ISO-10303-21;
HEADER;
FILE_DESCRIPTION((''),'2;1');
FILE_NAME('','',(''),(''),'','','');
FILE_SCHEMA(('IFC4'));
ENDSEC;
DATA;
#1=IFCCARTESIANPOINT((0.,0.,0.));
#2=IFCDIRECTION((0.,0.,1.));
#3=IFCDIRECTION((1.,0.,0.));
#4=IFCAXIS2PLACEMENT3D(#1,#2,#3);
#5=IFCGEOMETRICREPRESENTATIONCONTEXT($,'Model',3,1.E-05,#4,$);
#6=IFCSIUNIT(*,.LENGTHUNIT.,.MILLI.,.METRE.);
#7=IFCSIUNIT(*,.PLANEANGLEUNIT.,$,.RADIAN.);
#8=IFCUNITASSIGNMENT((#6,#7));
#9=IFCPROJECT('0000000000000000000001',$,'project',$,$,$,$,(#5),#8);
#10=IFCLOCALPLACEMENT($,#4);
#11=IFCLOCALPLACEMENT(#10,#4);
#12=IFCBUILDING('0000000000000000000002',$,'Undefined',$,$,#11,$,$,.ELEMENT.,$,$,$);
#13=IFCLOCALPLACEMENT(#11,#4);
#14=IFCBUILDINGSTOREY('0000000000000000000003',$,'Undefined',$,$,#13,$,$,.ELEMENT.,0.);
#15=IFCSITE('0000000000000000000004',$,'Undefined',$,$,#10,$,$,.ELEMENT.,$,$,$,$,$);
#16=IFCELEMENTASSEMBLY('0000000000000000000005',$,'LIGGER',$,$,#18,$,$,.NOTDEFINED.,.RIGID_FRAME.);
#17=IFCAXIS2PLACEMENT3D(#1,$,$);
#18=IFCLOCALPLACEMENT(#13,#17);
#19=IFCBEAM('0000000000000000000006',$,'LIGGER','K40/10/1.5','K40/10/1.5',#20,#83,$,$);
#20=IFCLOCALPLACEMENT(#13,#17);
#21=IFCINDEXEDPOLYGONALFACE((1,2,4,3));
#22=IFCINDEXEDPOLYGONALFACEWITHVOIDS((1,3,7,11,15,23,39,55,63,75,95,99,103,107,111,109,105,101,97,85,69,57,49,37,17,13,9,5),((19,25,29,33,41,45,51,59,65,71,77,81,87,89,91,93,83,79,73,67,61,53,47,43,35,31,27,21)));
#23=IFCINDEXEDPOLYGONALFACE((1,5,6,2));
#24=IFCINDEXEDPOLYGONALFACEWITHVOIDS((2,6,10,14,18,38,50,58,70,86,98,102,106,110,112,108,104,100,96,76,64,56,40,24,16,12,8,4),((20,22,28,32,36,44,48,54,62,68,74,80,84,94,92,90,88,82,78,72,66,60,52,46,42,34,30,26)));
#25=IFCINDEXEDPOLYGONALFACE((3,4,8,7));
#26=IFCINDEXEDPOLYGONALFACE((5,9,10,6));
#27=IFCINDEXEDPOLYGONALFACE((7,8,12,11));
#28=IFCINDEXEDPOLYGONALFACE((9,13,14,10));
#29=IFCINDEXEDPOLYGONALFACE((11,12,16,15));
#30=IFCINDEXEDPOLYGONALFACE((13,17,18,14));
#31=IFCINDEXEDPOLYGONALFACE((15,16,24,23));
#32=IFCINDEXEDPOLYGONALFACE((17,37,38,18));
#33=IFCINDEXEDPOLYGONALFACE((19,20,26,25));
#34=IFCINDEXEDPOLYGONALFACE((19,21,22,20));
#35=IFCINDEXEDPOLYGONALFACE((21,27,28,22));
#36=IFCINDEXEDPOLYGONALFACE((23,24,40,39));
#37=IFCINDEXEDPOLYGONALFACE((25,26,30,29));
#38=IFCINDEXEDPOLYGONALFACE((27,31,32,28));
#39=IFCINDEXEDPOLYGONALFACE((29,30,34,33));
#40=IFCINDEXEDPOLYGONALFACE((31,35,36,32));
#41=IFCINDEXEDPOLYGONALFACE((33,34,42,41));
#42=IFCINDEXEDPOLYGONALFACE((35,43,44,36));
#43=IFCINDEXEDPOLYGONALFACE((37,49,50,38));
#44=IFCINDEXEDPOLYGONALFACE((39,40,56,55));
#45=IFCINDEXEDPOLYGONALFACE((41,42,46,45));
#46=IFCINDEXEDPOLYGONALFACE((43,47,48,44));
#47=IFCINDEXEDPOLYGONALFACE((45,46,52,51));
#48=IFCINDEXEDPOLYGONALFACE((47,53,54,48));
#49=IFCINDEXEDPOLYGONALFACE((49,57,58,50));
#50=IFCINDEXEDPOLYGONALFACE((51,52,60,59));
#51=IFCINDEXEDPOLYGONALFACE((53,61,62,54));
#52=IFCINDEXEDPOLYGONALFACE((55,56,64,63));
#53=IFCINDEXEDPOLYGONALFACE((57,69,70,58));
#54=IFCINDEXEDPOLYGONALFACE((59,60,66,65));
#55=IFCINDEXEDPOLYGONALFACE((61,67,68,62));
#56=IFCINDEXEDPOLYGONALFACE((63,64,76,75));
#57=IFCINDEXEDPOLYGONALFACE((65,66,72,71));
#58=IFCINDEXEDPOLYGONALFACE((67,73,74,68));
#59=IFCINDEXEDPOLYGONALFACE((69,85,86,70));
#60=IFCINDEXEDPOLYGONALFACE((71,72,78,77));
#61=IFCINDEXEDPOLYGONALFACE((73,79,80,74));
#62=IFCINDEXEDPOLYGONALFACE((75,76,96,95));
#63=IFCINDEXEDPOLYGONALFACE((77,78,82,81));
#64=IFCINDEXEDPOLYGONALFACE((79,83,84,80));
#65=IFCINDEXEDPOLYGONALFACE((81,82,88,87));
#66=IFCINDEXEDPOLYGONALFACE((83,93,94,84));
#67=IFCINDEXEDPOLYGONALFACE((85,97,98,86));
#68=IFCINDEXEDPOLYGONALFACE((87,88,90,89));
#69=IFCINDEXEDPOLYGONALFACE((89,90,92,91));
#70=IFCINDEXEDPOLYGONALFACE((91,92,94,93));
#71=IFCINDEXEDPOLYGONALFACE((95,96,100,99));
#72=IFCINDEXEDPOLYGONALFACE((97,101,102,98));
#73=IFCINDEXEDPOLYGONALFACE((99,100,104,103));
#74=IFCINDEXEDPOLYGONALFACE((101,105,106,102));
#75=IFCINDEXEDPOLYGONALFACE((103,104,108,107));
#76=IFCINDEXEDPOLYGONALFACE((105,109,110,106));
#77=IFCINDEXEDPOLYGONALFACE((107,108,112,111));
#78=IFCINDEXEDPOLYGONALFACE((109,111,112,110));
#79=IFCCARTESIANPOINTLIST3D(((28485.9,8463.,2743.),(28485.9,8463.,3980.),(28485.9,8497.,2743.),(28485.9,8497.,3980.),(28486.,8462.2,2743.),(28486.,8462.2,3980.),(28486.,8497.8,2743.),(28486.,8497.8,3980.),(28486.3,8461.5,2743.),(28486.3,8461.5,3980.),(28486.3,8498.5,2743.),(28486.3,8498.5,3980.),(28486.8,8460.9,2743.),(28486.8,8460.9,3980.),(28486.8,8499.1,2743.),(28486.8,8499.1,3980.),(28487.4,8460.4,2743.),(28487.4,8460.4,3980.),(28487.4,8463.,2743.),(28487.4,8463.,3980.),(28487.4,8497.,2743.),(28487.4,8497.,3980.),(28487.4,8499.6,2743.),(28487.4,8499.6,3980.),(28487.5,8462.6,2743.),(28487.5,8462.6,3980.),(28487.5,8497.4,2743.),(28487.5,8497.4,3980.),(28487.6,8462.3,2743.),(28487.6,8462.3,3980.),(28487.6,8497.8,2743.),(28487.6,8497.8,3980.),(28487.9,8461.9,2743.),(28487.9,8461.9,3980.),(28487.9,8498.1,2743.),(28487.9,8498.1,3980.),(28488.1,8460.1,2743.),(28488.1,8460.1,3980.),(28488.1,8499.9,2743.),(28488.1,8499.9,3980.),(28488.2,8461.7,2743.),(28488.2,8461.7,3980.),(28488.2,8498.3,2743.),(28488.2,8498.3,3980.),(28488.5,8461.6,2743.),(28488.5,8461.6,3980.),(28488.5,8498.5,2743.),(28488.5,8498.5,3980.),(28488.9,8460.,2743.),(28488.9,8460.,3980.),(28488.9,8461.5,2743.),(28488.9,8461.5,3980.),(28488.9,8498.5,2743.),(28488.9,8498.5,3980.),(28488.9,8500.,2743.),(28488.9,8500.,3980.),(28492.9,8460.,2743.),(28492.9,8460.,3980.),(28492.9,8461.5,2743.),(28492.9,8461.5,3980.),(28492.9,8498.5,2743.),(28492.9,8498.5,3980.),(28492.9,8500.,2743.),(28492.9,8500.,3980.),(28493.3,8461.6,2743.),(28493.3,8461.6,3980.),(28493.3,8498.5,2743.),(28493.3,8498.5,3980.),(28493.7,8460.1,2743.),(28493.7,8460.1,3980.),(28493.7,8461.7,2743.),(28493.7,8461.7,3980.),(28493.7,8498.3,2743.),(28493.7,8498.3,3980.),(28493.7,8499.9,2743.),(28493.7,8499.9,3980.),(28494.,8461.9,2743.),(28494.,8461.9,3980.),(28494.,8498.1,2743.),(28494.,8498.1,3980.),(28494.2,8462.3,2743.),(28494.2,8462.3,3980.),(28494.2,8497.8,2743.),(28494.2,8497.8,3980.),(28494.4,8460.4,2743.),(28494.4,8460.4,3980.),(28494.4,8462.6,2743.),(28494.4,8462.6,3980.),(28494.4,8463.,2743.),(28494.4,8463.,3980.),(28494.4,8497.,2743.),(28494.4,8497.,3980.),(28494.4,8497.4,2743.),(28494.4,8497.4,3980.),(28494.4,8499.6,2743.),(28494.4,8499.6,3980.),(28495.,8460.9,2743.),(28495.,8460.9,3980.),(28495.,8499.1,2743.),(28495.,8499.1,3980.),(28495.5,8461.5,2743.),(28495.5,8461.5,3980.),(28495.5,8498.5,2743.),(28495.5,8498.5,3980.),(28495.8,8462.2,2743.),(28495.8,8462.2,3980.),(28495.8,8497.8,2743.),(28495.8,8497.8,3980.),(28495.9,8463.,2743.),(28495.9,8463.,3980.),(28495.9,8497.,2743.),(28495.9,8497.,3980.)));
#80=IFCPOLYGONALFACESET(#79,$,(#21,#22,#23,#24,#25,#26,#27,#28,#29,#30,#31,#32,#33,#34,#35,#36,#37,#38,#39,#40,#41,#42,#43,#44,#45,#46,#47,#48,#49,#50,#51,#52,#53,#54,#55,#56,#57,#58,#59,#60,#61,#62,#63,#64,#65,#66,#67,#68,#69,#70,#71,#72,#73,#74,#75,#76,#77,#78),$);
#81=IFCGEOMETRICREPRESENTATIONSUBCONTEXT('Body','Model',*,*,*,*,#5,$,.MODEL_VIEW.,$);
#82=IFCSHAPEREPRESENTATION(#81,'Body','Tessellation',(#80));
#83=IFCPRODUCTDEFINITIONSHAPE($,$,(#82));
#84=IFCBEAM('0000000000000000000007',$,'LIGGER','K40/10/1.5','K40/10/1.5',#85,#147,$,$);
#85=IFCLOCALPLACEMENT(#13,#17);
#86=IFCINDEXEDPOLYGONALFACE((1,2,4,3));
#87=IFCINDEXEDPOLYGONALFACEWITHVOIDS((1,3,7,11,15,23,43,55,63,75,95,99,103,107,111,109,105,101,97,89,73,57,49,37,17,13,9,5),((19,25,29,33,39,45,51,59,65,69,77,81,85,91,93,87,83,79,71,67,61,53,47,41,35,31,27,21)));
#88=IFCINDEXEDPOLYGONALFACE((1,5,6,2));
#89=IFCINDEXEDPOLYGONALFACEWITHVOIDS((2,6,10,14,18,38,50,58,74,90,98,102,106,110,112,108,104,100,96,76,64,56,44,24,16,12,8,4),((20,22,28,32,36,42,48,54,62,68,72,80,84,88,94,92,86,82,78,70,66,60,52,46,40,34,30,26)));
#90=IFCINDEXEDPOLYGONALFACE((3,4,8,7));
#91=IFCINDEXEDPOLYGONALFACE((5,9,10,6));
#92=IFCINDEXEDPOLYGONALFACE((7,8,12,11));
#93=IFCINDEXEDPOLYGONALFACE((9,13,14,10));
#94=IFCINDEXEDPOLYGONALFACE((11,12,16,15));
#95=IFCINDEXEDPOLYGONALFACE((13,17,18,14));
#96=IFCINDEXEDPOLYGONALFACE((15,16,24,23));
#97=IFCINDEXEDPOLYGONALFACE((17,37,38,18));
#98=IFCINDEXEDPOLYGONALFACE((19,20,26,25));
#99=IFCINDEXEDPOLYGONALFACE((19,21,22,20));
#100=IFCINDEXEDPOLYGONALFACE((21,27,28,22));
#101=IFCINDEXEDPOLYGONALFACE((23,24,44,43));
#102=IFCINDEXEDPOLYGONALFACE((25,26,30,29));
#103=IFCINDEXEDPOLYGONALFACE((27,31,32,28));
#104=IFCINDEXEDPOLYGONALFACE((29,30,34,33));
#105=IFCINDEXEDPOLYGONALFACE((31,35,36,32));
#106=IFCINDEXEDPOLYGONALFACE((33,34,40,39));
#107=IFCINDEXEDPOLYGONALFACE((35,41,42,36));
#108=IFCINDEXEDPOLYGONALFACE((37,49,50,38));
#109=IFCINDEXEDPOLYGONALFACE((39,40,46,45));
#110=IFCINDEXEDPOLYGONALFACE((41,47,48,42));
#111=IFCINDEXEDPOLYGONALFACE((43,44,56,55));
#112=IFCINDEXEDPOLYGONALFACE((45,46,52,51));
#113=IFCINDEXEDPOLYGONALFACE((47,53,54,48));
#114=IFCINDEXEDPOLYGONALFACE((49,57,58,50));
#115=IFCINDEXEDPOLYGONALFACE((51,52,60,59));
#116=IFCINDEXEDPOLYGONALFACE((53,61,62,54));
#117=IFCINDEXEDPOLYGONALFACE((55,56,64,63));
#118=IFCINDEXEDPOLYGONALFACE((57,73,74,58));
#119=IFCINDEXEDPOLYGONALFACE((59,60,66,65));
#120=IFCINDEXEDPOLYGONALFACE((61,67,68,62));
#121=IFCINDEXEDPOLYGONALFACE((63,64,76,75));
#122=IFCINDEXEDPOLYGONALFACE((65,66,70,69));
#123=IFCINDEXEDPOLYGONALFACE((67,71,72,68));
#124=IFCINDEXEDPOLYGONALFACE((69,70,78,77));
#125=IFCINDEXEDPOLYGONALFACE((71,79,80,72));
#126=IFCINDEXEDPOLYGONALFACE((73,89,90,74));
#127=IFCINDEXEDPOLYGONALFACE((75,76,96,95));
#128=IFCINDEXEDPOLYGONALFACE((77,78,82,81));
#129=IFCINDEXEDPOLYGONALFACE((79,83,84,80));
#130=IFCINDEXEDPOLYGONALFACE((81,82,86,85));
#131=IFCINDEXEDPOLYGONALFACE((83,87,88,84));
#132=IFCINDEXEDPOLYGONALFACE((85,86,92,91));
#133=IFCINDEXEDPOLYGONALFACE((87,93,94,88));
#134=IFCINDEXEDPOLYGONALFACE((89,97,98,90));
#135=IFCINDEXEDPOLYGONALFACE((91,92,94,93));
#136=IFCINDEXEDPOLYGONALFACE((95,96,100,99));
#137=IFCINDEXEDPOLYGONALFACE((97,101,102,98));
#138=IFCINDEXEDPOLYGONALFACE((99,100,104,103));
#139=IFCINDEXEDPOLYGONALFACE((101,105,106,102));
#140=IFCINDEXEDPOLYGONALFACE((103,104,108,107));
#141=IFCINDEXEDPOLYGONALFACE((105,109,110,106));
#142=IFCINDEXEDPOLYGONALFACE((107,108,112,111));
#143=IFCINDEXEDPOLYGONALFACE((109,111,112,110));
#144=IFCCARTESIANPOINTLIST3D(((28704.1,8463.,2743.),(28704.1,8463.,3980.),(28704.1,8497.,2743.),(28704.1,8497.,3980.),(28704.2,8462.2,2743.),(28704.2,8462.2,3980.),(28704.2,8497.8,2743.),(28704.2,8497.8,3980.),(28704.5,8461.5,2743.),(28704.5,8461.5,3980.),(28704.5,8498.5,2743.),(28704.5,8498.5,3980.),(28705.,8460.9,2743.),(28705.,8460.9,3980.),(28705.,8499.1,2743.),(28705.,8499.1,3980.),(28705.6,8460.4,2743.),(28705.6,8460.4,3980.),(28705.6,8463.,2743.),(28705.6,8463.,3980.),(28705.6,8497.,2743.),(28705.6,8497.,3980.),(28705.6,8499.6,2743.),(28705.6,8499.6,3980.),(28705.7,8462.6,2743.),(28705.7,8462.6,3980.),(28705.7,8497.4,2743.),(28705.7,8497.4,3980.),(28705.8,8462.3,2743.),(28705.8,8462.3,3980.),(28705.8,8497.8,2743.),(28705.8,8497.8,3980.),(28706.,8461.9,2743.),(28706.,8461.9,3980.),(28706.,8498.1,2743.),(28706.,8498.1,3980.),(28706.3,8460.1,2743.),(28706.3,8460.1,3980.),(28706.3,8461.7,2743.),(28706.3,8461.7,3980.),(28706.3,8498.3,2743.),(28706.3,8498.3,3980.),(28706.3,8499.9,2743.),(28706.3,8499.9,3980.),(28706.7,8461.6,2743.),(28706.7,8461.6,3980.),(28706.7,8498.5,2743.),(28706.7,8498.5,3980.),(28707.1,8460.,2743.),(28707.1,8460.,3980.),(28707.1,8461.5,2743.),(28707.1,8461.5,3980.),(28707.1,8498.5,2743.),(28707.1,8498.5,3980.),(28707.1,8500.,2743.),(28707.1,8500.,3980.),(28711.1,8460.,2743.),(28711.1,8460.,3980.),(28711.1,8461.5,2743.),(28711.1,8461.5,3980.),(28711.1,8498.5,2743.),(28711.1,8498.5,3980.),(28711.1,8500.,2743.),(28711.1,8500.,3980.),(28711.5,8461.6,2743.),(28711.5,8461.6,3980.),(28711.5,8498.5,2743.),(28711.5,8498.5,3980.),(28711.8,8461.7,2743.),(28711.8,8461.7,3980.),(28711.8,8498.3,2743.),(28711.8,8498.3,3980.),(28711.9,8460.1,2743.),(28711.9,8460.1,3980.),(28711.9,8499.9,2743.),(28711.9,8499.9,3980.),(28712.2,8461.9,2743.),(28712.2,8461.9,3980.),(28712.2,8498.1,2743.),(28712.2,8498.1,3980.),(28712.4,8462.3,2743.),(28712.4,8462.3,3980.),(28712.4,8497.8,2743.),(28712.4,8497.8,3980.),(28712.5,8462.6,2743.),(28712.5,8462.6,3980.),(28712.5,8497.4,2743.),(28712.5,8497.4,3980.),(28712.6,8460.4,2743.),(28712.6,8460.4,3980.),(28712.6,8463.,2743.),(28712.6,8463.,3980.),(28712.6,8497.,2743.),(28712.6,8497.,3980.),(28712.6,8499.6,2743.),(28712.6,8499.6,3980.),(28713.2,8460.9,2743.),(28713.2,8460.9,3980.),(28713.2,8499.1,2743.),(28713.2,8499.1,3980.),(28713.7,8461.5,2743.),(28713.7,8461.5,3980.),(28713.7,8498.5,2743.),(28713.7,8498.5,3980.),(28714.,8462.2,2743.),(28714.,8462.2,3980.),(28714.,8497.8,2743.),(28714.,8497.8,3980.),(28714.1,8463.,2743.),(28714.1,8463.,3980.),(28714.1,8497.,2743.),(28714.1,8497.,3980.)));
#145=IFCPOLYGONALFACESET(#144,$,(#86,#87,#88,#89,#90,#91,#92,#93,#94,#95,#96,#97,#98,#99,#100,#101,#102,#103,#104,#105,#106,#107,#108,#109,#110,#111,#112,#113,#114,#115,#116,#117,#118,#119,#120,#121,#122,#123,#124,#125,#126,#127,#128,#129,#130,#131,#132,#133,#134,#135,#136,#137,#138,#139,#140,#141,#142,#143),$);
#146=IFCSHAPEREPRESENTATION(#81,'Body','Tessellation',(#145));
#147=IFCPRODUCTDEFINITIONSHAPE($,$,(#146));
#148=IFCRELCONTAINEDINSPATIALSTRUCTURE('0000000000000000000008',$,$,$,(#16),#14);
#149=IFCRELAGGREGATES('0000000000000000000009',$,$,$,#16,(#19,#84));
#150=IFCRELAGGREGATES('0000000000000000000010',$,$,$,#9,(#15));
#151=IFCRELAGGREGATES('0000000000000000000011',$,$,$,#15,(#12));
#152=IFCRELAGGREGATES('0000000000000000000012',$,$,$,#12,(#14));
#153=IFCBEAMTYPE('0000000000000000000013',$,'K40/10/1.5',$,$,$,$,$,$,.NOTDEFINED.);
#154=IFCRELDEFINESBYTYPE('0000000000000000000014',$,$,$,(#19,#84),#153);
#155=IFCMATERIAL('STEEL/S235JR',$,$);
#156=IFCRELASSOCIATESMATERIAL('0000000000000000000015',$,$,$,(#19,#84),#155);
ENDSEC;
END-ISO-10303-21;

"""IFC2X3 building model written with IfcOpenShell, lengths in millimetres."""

from ifc_helpers import new_model, si_unit, frame, origin_with_axes, origin_2d_with_axis, place, context, subcontext, project, spatial, hollow_rectangle, extrude, clip, halfspace, material, type_object, element, aggregate, save


model = new_model("IFC2X3")

# Units and contexts
model_context = context("Model", 3, precision=1e-05, world=origin_with_axes())
body_context = subcontext(model_context, "Body", "Model", "MODEL_VIEW")
ifc_project = project(units=[si_unit("LENGTHUNIT", "METRE", prefix="MILLI"), si_unit("PLANEANGLEUNIT", "RADIAN")], contexts=[model_context])

# Site, building, storey
site_placement = place(None, origin_with_axes())
site = spatial("IfcSite", under=ifc_project, at=site_placement, Name="Undefined", CompositionType="ELEMENT")
building_placement = place(site_placement, origin_with_axes())
building = spatial("IfcBuilding", under=site, at=building_placement, Name="Undefined", CompositionType="ELEMENT")
storey_placement = place(building_placement, origin_with_axes())
storey = spatial("IfcBuildingStorey", under=building, at=storey_placement, Name="Undefined", CompositionType="ELEMENT", Elevation=0.0)

# Element assembly, beams
ifc_material_1 = material(Name="STEEL/S235JR")
assembly_1_placement = place(storey_placement, origin_with_axes())
assembly_1 = element("IfcElementAssembly", 1, at=assembly_1_placement, inside=storey, Name="LIGGER", AssemblyPlace="NOTDEFINED", PredefinedType="RIGID_FRAME")
beam_type_1 = type_object("IfcBeamType", Name="K40/10/1.5", PredefinedType="NOTDEFINED")
beam_1_placement = place(assembly_1_placement, frame((28490.9, 8480.0, 3980.0), z_axis=(0.0, 1.0, 0.0), x_axis=(0.0, 0.0, -1.0)))
beam_1 = element("IfcBeam", 2, at=beam_1_placement, type_object=beam_type_1, material=ifc_material_1, Name="LIGGER", Description="K40/10/1.5", ObjectType="K40/10/1.5", context=body_context, shape_type="Clipping", body=[
    clip(extrude(hollow_rectangle(XDim=10.0, YDim=40.0, WallThickness=1.5, InnerFilletRadius=1.5, OuterFilletRadius=3.0, at=origin_2d_with_axis()), frame((1237.0, 0.0, 0.0), z_axis=(-1.0, 0.0, 0.0), x_axis=(0.0, -1.0, 0.0)), (0.0, 0.0, 1.0), 1237.0), halfspace(frame((1237.0, 4.3, 47.4), z_axis=(1.0, 0.0, 0.0), x_axis=(0.0, -0.768355, -0.640024)), False)),
])
beam_2_placement = place(assembly_1_placement, frame((28709.1, 8480.0, 3980.0), z_axis=(0.0, 1.0, 0.0), x_axis=(0.0, 0.0, -1.0)))
beam_2 = element("IfcBeam", 3, at=beam_2_placement, type_object=beam_type_1, material=ifc_material_1, Name="LIGGER", Description="K40/10/1.5", ObjectType="K40/10/1.5", context=body_context, shape_type="Clipping", body=[
    clip(extrude(hollow_rectangle(XDim=10.0, YDim=40.0, WallThickness=1.5, InnerFilletRadius=1.5, OuterFilletRadius=3.0, at=origin_2d_with_axis()), frame((1237.0, 0.0, 0.0), z_axis=(-1.0, 0.0, 0.0), x_axis=(0.0, -1.0, 0.0)), (0.0, 0.0, 1.0), 1237.0), halfspace(frame((1237.0, 4.3, 47.4), z_axis=(1.0, 0.0, 0.0), x_axis=(0.0, -0.768355, -0.640024)), False)),
])

aggregate(assembly_1, [beam_1, beam_2])

save(model, "model.ifc")
